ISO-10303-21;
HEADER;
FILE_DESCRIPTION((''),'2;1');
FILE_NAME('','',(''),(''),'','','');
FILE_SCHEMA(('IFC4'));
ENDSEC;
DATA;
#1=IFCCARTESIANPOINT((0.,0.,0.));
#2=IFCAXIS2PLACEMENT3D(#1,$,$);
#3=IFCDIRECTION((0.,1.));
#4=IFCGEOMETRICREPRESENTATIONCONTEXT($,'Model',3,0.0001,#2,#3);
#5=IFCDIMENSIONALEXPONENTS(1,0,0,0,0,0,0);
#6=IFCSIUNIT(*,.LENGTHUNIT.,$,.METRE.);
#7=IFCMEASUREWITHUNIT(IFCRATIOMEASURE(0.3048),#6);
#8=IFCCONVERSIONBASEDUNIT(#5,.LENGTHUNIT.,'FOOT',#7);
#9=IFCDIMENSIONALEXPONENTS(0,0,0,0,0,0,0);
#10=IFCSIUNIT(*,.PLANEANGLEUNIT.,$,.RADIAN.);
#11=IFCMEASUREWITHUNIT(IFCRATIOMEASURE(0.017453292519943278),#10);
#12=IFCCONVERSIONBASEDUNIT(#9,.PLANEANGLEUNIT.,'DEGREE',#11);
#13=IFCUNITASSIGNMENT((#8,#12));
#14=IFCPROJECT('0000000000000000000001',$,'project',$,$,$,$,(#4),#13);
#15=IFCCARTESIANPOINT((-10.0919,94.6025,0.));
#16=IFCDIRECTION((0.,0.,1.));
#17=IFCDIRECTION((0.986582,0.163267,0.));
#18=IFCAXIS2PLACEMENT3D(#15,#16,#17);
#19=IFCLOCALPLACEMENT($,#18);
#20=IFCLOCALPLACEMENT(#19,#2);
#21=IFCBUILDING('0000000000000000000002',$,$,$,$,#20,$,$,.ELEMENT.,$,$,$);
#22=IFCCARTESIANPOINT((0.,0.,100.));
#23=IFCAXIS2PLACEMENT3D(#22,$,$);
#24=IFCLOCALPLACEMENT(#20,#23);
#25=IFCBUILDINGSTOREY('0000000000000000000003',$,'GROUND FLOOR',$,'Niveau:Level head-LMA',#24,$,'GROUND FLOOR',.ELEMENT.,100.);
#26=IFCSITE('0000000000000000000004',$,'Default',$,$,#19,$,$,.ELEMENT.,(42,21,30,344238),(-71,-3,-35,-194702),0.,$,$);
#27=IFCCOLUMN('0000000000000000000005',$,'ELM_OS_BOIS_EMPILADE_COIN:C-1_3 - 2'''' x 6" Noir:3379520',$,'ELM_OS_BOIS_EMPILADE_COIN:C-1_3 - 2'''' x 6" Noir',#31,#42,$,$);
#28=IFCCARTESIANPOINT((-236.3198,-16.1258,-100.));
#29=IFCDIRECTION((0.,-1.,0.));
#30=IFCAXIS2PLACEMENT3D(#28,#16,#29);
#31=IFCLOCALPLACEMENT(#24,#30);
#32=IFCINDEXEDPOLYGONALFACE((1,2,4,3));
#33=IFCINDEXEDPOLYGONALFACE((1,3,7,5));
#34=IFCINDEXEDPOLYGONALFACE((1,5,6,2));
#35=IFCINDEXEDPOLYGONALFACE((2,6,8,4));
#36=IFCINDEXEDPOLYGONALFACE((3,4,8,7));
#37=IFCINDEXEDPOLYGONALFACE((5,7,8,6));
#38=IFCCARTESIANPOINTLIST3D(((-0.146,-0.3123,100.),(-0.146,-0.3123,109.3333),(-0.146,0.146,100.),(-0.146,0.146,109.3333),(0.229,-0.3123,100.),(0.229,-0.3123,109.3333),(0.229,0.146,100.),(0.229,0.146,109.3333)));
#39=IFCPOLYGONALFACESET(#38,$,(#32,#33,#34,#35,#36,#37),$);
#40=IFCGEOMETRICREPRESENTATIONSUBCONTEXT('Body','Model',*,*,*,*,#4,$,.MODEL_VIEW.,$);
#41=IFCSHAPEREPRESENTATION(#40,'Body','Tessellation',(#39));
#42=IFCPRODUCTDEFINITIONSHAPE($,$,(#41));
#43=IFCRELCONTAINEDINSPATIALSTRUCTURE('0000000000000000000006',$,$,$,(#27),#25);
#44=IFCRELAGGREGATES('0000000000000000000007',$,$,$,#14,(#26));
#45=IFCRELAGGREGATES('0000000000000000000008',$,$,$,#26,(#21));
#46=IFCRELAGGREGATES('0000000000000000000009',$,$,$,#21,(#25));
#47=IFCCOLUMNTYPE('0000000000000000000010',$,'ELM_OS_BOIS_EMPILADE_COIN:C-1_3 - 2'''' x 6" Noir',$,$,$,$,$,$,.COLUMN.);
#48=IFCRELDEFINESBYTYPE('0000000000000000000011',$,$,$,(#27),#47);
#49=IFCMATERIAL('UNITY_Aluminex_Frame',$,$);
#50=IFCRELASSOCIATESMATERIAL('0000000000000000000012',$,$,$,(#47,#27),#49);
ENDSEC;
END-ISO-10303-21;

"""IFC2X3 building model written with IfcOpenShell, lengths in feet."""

from ifc_helpers import new_model, entity, si_unit, converted_unit, direction, frame, origin, origin_2d_with_axis, place, context, subcontext, project, spatial, rectangle, extrude, source, transform, mapped, material, type_object, type_shapes, element, save


model = new_model("IFC2X3")

# Units and contexts
model_context = context("Model", 3, precision=0.0001, world=origin(), true_north=direction((0.0, 1.0)))
body_context = subcontext(model_context, "Body", "Model", "MODEL_VIEW")
ifc_project = project(units=[converted_unit("LENGTHUNIT", "FOOT", entity("IfcRatioMeasure", 0.3048), si_unit("LENGTHUNIT", "METRE"), dimensions=[1, 0, 0, 0, 0, 0, 0]), converted_unit("PLANEANGLEUNIT", "DEGREE", entity("IfcRatioMeasure", 0.017453292519943278), si_unit("PLANEANGLEUNIT", "RADIAN"), dimensions=[0, 0, 0, 0, 0, 0, 0])], contexts=[model_context])

# Site, building, storey
site_placement = place(None, frame((-10.0919, 94.6025, 0.0), z_axis=(0.0, 0.0, 1.0), x_axis=(0.986582, 0.163267, 0.0)))
site = spatial("IfcSite", under=ifc_project, at=site_placement, Name="Default", CompositionType="ELEMENT", RefLatitude=(42, 21, 30, 344238), RefLongitude=(-71, -3, -35, -194702), RefElevation=0.0)
building_placement = place(site_placement, origin())
building = spatial("IfcBuilding", under=site, at=building_placement, CompositionType="ELEMENT")
storey_placement = place(building_placement, frame((0.0, 0.0, 100.0)))
storey = spatial("IfcBuildingStorey", under=building, at=storey_placement, Name="GROUND FLOOR", ObjectType="Niveau:Level head-LMA", LongName="GROUND FLOOR", CompositionType="ELEMENT", Elevation=100.0)

# Column
ifc_material_1 = material(Name="UNITY_Aluminex_Frame")
column_type = type_object("IfcColumnType", Name="ELM_OS_BOIS_EMPILADE_COIN:C-1_3 - 2'' x 6\" Noir", PredefinedType="COLUMN", material=ifc_material_1)
shared_shape = source(origin(), body_context, "Body", "SweptSolid", [
    extrude(rectangle(XDim=0.4583, YDim=0.375, at=origin_2d_with_axis()), frame((0.0415, -0.0832, 100.0), z_axis=(0.0, 0.0, 1.0), x_axis=(0.0, -1.0, 0.0)), (0.0, 0.0, 1.0), 9.3333),
])
type_shapes(column_type, [shared_shape])
column_placement = place(storey_placement, frame((-236.3198, -16.1258, -100.0), z_axis=(0.0, 0.0, 1.0), x_axis=(0.0, -1.0, 0.0)))
element("IfcColumn", 1, at=column_placement, inside=storey, type_object=column_type, material=ifc_material_1, Name="ELM_OS_BOIS_EMPILADE_COIN:C-1_3 - 2'' x 6\" Noir:3379520", ObjectType="ELM_OS_BOIS_EMPILADE_COIN:C-1_3 - 2'' x 6\" Noir", context=body_context, shape_type="MappedRepresentation", body=[
    mapped(shared_shape, transform((0.0, 0.0, 0.0), scale=1.0)),
])

save(model, "model.ifc")
